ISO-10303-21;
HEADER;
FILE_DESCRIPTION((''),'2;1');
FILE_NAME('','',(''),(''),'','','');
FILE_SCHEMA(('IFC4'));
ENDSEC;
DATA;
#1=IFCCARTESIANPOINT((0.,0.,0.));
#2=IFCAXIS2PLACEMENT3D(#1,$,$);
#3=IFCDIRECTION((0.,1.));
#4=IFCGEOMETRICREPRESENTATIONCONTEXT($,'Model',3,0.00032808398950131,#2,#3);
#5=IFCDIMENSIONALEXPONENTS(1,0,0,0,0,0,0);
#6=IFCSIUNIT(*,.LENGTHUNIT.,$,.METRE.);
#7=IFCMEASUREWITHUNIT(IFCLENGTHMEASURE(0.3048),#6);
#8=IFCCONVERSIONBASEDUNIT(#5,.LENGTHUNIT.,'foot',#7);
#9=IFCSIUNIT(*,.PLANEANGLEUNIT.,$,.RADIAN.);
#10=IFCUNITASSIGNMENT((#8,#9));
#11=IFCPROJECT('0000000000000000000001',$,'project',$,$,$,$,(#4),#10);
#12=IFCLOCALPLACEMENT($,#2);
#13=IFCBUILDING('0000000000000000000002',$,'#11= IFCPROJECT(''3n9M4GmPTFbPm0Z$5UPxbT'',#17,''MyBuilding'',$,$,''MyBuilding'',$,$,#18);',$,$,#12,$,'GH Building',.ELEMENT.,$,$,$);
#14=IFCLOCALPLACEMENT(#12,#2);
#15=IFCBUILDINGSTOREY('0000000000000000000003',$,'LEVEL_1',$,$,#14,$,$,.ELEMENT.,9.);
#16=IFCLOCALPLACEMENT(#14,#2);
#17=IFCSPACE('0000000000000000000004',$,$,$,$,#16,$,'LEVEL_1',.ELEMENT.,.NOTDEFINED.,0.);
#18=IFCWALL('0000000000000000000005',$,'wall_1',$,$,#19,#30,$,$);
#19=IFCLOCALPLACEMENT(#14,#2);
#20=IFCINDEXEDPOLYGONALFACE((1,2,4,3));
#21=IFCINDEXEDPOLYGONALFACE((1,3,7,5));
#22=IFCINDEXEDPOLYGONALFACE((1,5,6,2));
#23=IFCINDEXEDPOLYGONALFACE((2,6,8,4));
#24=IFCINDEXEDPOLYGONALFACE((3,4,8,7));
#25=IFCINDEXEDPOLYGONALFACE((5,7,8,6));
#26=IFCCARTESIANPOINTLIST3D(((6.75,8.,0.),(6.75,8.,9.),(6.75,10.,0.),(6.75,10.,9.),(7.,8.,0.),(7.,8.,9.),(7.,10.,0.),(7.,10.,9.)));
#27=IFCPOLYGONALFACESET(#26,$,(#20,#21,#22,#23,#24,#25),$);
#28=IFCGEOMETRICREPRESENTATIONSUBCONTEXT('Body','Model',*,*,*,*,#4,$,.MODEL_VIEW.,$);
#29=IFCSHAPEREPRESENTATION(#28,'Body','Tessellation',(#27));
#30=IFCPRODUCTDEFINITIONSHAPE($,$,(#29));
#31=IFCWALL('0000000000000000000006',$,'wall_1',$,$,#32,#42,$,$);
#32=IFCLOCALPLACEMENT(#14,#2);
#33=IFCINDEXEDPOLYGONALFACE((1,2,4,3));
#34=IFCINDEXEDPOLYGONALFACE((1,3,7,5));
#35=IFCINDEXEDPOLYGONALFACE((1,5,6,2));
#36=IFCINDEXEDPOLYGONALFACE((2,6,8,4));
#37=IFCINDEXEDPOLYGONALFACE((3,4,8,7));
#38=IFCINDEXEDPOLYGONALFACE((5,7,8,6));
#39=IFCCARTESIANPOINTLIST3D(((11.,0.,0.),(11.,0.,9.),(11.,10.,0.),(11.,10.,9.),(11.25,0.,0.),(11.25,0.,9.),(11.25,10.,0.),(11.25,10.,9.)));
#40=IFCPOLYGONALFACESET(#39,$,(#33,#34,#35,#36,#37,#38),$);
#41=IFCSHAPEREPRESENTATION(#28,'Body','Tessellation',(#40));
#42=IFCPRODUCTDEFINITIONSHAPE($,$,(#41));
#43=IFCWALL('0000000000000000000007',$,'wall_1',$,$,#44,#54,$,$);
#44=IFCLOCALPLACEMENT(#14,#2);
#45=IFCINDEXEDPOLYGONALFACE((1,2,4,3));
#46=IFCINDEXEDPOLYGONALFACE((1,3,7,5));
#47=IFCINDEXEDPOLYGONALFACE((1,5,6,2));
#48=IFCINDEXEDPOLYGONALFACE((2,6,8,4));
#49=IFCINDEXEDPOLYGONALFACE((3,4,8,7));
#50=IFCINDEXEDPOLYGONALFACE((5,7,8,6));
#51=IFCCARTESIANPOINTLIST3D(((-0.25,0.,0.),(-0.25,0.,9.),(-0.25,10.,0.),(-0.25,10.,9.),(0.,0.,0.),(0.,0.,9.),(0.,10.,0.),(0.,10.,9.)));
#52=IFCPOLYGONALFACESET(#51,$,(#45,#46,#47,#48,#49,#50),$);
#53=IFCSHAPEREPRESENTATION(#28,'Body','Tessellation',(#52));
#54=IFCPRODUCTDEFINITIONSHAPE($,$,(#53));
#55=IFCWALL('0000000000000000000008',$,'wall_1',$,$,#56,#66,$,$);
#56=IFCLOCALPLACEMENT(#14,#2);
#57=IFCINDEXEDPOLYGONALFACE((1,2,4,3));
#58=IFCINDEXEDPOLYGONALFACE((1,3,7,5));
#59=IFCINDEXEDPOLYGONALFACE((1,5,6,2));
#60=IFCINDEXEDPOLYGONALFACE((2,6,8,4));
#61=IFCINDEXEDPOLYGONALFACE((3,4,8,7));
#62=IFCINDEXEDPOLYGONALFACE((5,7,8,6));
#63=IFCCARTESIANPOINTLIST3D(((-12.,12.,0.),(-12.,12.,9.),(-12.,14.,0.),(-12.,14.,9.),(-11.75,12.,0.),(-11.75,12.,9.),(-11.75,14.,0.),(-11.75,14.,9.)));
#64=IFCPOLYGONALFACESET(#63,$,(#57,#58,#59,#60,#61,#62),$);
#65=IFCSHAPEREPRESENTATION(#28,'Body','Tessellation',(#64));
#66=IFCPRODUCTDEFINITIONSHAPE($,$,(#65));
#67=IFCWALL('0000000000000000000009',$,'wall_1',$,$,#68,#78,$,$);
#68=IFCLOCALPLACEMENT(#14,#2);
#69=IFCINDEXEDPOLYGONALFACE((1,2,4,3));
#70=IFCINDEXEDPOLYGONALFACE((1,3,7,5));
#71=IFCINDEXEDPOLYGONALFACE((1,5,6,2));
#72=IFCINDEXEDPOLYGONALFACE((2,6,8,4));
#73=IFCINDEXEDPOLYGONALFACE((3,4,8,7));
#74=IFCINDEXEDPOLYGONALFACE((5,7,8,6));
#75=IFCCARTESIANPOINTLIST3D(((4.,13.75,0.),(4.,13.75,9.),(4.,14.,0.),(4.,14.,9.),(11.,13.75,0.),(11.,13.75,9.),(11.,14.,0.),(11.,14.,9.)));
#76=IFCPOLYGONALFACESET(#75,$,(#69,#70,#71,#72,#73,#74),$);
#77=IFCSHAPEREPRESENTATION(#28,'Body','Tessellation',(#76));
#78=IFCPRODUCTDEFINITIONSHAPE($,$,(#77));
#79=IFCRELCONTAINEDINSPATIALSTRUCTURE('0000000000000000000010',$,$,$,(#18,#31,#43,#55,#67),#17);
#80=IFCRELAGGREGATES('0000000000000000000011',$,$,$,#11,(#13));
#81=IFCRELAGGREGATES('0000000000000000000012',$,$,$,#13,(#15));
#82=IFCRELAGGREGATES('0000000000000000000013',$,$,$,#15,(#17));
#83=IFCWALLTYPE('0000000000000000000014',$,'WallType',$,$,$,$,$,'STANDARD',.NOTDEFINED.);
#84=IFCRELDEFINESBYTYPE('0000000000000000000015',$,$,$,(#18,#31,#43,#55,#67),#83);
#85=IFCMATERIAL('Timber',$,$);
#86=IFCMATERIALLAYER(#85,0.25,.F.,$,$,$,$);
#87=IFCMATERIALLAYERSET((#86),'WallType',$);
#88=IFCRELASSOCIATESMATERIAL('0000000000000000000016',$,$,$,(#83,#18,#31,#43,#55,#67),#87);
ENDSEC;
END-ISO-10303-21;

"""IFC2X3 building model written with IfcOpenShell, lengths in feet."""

from ifc_helpers import new_model, entity, si_unit, converted_unit, direction, frame, frame_2d, origin, place, context, subcontext, project, spatial, rectangle, extrude, material, layer, layer_set, layer_usage, type_object, element, save


model = new_model("IFC2X3")

# Units and contexts
model_context = context("Model", 3, precision=0.00032808398950131, world=origin(), true_north=direction((0.0, 1.0)))
body_context = subcontext(model_context, "Body", "Model", "MODEL_VIEW")
ifc_project = project(units=[converted_unit("LENGTHUNIT", "foot", entity("IfcLengthMeasure", 0.3048), si_unit("LENGTHUNIT", "METRE"), dimensions=[1, 0, 0, 0, 0, 0, 0]), si_unit("PLANEANGLEUNIT", "RADIAN")], contexts=[model_context])

# Building, storey, space
building_placement = place(None, origin())
building = spatial("IfcBuilding", under=ifc_project, at=building_placement, Name="#11= IFCPROJECT('3n9M4GmPTFbPm0Z$5UPxbT',#17,'MyBuilding',$,$,'MyBuilding',$,$,#18);", LongName="GH Building", CompositionType="ELEMENT")
storey_placement = place(building_placement, origin())
storey = spatial("IfcBuildingStorey", under=building, at=storey_placement, Name="LEVEL_1", CompositionType="ELEMENT", Elevation=9.0)
space_placement = place(storey_placement, origin())
space = spatial("IfcSpace", under=storey, at=space_placement, LongName="LEVEL_1", CompositionType="ELEMENT", InteriorOrExteriorSpace="NOTDEFINED", ElevationWithFlooring=0.0)

# Wall
ifc_material = material(Name="Timber")
ifc_layer = layer(ifc_material, 0.25, ventilated=False)
ifc_layer_set = layer_set([ifc_layer], Name="WallType")
ifc_layer_usage_1 = layer_usage(ifc_layer_set, "AXIS2", "NEGATIVE", 0.0)
wall_type = type_object("IfcWallType", Name="WallType", ElementType="STANDARD", PredefinedType="NOTDEFINED", material=ifc_layer_set)
wall_1_placement = place(space_placement, frame((7.0, 10.0, 0.0), z_axis=(0.0, 0.0, 1.0), x_axis=(0.0, -1.0, 0.0)))
element("IfcWall", 1, at=wall_1_placement, inside=space, type_object=wall_type, material=ifc_layer_usage_1, Name="wall_1", context=body_context, shape_type="SweptSolid", body=[
    extrude(rectangle(XDim=2.0, YDim=0.25, at=frame_2d((1.0, -0.125))), origin(), (0.0, 0.0, 1.0), 9.0),
])

# Wall
ifc_layer_usage_2 = layer_usage(ifc_layer_set, "AXIS2", "NEGATIVE", 0.0)
wall_2_placement = place(space_placement, frame((11.0, 0.0, 0.0), z_axis=(0.0, 0.0, 1.0), x_axis=(0.0, 1.0, 0.0)))
element("IfcWall", 2, at=wall_2_placement, inside=space, type_object=wall_type, material=ifc_layer_usage_2, Name="wall_1", context=body_context, shape_type="SweptSolid", body=[
    extrude(rectangle(XDim=10.0, YDim=0.25, at=frame_2d((5.0, -0.125))), origin(), (0.0, 0.0, 1.0), 9.0),
])

# Wall
ifc_layer_usage_3 = layer_usage(ifc_layer_set, "AXIS2", "NEGATIVE", 0.0)
wall_3_placement = place(space_placement, frame((0.0, 10.0, 0.0), z_axis=(0.0, 0.0, 1.0), x_axis=(0.0, -1.0, 0.0)))
element("IfcWall", 3, at=wall_3_placement, inside=space, type_object=wall_type, material=ifc_layer_usage_3, Name="wall_1", context=body_context, shape_type="SweptSolid", body=[
    extrude(rectangle(XDim=10.0, YDim=0.25, at=frame_2d((5.0, -0.125))), origin(), (0.0, 0.0, 1.0), 9.0),
])

# Wall
ifc_layer_usage_4 = layer_usage(ifc_layer_set, "AXIS2", "NEGATIVE", 0.0)
wall_4_placement = place(space_placement, frame((-12.0, 12.0, 0.0), z_axis=(0.0, 0.0, 1.0), x_axis=(0.0, 1.0, 0.0)))
element("IfcWall", 4, at=wall_4_placement, inside=space, type_object=wall_type, material=ifc_layer_usage_4, Name="wall_1", context=body_context, shape_type="SweptSolid", body=[
    extrude(rectangle(XDim=2.0, YDim=0.25, at=frame_2d((1.0, -0.125))), origin(), (0.0, 0.0, 1.0), 9.0),
])

# Wall
ifc_layer_usage_5 = layer_usage(ifc_layer_set, "AXIS2", "NEGATIVE", 0.0)
wall_5_placement = place(space_placement, frame((4.0, 14.0, 0.0)))
element("IfcWall", 5, at=wall_5_placement, inside=space, type_object=wall_type, material=ifc_layer_usage_5, Name="wall_1", context=body_context, shape_type="SweptSolid", body=[
    extrude(rectangle(XDim=7.0, YDim=0.25, at=frame_2d((3.5, -0.125))), origin(), (0.0, 0.0, 1.0), 9.0),
])

save(model, "model.ifc")
